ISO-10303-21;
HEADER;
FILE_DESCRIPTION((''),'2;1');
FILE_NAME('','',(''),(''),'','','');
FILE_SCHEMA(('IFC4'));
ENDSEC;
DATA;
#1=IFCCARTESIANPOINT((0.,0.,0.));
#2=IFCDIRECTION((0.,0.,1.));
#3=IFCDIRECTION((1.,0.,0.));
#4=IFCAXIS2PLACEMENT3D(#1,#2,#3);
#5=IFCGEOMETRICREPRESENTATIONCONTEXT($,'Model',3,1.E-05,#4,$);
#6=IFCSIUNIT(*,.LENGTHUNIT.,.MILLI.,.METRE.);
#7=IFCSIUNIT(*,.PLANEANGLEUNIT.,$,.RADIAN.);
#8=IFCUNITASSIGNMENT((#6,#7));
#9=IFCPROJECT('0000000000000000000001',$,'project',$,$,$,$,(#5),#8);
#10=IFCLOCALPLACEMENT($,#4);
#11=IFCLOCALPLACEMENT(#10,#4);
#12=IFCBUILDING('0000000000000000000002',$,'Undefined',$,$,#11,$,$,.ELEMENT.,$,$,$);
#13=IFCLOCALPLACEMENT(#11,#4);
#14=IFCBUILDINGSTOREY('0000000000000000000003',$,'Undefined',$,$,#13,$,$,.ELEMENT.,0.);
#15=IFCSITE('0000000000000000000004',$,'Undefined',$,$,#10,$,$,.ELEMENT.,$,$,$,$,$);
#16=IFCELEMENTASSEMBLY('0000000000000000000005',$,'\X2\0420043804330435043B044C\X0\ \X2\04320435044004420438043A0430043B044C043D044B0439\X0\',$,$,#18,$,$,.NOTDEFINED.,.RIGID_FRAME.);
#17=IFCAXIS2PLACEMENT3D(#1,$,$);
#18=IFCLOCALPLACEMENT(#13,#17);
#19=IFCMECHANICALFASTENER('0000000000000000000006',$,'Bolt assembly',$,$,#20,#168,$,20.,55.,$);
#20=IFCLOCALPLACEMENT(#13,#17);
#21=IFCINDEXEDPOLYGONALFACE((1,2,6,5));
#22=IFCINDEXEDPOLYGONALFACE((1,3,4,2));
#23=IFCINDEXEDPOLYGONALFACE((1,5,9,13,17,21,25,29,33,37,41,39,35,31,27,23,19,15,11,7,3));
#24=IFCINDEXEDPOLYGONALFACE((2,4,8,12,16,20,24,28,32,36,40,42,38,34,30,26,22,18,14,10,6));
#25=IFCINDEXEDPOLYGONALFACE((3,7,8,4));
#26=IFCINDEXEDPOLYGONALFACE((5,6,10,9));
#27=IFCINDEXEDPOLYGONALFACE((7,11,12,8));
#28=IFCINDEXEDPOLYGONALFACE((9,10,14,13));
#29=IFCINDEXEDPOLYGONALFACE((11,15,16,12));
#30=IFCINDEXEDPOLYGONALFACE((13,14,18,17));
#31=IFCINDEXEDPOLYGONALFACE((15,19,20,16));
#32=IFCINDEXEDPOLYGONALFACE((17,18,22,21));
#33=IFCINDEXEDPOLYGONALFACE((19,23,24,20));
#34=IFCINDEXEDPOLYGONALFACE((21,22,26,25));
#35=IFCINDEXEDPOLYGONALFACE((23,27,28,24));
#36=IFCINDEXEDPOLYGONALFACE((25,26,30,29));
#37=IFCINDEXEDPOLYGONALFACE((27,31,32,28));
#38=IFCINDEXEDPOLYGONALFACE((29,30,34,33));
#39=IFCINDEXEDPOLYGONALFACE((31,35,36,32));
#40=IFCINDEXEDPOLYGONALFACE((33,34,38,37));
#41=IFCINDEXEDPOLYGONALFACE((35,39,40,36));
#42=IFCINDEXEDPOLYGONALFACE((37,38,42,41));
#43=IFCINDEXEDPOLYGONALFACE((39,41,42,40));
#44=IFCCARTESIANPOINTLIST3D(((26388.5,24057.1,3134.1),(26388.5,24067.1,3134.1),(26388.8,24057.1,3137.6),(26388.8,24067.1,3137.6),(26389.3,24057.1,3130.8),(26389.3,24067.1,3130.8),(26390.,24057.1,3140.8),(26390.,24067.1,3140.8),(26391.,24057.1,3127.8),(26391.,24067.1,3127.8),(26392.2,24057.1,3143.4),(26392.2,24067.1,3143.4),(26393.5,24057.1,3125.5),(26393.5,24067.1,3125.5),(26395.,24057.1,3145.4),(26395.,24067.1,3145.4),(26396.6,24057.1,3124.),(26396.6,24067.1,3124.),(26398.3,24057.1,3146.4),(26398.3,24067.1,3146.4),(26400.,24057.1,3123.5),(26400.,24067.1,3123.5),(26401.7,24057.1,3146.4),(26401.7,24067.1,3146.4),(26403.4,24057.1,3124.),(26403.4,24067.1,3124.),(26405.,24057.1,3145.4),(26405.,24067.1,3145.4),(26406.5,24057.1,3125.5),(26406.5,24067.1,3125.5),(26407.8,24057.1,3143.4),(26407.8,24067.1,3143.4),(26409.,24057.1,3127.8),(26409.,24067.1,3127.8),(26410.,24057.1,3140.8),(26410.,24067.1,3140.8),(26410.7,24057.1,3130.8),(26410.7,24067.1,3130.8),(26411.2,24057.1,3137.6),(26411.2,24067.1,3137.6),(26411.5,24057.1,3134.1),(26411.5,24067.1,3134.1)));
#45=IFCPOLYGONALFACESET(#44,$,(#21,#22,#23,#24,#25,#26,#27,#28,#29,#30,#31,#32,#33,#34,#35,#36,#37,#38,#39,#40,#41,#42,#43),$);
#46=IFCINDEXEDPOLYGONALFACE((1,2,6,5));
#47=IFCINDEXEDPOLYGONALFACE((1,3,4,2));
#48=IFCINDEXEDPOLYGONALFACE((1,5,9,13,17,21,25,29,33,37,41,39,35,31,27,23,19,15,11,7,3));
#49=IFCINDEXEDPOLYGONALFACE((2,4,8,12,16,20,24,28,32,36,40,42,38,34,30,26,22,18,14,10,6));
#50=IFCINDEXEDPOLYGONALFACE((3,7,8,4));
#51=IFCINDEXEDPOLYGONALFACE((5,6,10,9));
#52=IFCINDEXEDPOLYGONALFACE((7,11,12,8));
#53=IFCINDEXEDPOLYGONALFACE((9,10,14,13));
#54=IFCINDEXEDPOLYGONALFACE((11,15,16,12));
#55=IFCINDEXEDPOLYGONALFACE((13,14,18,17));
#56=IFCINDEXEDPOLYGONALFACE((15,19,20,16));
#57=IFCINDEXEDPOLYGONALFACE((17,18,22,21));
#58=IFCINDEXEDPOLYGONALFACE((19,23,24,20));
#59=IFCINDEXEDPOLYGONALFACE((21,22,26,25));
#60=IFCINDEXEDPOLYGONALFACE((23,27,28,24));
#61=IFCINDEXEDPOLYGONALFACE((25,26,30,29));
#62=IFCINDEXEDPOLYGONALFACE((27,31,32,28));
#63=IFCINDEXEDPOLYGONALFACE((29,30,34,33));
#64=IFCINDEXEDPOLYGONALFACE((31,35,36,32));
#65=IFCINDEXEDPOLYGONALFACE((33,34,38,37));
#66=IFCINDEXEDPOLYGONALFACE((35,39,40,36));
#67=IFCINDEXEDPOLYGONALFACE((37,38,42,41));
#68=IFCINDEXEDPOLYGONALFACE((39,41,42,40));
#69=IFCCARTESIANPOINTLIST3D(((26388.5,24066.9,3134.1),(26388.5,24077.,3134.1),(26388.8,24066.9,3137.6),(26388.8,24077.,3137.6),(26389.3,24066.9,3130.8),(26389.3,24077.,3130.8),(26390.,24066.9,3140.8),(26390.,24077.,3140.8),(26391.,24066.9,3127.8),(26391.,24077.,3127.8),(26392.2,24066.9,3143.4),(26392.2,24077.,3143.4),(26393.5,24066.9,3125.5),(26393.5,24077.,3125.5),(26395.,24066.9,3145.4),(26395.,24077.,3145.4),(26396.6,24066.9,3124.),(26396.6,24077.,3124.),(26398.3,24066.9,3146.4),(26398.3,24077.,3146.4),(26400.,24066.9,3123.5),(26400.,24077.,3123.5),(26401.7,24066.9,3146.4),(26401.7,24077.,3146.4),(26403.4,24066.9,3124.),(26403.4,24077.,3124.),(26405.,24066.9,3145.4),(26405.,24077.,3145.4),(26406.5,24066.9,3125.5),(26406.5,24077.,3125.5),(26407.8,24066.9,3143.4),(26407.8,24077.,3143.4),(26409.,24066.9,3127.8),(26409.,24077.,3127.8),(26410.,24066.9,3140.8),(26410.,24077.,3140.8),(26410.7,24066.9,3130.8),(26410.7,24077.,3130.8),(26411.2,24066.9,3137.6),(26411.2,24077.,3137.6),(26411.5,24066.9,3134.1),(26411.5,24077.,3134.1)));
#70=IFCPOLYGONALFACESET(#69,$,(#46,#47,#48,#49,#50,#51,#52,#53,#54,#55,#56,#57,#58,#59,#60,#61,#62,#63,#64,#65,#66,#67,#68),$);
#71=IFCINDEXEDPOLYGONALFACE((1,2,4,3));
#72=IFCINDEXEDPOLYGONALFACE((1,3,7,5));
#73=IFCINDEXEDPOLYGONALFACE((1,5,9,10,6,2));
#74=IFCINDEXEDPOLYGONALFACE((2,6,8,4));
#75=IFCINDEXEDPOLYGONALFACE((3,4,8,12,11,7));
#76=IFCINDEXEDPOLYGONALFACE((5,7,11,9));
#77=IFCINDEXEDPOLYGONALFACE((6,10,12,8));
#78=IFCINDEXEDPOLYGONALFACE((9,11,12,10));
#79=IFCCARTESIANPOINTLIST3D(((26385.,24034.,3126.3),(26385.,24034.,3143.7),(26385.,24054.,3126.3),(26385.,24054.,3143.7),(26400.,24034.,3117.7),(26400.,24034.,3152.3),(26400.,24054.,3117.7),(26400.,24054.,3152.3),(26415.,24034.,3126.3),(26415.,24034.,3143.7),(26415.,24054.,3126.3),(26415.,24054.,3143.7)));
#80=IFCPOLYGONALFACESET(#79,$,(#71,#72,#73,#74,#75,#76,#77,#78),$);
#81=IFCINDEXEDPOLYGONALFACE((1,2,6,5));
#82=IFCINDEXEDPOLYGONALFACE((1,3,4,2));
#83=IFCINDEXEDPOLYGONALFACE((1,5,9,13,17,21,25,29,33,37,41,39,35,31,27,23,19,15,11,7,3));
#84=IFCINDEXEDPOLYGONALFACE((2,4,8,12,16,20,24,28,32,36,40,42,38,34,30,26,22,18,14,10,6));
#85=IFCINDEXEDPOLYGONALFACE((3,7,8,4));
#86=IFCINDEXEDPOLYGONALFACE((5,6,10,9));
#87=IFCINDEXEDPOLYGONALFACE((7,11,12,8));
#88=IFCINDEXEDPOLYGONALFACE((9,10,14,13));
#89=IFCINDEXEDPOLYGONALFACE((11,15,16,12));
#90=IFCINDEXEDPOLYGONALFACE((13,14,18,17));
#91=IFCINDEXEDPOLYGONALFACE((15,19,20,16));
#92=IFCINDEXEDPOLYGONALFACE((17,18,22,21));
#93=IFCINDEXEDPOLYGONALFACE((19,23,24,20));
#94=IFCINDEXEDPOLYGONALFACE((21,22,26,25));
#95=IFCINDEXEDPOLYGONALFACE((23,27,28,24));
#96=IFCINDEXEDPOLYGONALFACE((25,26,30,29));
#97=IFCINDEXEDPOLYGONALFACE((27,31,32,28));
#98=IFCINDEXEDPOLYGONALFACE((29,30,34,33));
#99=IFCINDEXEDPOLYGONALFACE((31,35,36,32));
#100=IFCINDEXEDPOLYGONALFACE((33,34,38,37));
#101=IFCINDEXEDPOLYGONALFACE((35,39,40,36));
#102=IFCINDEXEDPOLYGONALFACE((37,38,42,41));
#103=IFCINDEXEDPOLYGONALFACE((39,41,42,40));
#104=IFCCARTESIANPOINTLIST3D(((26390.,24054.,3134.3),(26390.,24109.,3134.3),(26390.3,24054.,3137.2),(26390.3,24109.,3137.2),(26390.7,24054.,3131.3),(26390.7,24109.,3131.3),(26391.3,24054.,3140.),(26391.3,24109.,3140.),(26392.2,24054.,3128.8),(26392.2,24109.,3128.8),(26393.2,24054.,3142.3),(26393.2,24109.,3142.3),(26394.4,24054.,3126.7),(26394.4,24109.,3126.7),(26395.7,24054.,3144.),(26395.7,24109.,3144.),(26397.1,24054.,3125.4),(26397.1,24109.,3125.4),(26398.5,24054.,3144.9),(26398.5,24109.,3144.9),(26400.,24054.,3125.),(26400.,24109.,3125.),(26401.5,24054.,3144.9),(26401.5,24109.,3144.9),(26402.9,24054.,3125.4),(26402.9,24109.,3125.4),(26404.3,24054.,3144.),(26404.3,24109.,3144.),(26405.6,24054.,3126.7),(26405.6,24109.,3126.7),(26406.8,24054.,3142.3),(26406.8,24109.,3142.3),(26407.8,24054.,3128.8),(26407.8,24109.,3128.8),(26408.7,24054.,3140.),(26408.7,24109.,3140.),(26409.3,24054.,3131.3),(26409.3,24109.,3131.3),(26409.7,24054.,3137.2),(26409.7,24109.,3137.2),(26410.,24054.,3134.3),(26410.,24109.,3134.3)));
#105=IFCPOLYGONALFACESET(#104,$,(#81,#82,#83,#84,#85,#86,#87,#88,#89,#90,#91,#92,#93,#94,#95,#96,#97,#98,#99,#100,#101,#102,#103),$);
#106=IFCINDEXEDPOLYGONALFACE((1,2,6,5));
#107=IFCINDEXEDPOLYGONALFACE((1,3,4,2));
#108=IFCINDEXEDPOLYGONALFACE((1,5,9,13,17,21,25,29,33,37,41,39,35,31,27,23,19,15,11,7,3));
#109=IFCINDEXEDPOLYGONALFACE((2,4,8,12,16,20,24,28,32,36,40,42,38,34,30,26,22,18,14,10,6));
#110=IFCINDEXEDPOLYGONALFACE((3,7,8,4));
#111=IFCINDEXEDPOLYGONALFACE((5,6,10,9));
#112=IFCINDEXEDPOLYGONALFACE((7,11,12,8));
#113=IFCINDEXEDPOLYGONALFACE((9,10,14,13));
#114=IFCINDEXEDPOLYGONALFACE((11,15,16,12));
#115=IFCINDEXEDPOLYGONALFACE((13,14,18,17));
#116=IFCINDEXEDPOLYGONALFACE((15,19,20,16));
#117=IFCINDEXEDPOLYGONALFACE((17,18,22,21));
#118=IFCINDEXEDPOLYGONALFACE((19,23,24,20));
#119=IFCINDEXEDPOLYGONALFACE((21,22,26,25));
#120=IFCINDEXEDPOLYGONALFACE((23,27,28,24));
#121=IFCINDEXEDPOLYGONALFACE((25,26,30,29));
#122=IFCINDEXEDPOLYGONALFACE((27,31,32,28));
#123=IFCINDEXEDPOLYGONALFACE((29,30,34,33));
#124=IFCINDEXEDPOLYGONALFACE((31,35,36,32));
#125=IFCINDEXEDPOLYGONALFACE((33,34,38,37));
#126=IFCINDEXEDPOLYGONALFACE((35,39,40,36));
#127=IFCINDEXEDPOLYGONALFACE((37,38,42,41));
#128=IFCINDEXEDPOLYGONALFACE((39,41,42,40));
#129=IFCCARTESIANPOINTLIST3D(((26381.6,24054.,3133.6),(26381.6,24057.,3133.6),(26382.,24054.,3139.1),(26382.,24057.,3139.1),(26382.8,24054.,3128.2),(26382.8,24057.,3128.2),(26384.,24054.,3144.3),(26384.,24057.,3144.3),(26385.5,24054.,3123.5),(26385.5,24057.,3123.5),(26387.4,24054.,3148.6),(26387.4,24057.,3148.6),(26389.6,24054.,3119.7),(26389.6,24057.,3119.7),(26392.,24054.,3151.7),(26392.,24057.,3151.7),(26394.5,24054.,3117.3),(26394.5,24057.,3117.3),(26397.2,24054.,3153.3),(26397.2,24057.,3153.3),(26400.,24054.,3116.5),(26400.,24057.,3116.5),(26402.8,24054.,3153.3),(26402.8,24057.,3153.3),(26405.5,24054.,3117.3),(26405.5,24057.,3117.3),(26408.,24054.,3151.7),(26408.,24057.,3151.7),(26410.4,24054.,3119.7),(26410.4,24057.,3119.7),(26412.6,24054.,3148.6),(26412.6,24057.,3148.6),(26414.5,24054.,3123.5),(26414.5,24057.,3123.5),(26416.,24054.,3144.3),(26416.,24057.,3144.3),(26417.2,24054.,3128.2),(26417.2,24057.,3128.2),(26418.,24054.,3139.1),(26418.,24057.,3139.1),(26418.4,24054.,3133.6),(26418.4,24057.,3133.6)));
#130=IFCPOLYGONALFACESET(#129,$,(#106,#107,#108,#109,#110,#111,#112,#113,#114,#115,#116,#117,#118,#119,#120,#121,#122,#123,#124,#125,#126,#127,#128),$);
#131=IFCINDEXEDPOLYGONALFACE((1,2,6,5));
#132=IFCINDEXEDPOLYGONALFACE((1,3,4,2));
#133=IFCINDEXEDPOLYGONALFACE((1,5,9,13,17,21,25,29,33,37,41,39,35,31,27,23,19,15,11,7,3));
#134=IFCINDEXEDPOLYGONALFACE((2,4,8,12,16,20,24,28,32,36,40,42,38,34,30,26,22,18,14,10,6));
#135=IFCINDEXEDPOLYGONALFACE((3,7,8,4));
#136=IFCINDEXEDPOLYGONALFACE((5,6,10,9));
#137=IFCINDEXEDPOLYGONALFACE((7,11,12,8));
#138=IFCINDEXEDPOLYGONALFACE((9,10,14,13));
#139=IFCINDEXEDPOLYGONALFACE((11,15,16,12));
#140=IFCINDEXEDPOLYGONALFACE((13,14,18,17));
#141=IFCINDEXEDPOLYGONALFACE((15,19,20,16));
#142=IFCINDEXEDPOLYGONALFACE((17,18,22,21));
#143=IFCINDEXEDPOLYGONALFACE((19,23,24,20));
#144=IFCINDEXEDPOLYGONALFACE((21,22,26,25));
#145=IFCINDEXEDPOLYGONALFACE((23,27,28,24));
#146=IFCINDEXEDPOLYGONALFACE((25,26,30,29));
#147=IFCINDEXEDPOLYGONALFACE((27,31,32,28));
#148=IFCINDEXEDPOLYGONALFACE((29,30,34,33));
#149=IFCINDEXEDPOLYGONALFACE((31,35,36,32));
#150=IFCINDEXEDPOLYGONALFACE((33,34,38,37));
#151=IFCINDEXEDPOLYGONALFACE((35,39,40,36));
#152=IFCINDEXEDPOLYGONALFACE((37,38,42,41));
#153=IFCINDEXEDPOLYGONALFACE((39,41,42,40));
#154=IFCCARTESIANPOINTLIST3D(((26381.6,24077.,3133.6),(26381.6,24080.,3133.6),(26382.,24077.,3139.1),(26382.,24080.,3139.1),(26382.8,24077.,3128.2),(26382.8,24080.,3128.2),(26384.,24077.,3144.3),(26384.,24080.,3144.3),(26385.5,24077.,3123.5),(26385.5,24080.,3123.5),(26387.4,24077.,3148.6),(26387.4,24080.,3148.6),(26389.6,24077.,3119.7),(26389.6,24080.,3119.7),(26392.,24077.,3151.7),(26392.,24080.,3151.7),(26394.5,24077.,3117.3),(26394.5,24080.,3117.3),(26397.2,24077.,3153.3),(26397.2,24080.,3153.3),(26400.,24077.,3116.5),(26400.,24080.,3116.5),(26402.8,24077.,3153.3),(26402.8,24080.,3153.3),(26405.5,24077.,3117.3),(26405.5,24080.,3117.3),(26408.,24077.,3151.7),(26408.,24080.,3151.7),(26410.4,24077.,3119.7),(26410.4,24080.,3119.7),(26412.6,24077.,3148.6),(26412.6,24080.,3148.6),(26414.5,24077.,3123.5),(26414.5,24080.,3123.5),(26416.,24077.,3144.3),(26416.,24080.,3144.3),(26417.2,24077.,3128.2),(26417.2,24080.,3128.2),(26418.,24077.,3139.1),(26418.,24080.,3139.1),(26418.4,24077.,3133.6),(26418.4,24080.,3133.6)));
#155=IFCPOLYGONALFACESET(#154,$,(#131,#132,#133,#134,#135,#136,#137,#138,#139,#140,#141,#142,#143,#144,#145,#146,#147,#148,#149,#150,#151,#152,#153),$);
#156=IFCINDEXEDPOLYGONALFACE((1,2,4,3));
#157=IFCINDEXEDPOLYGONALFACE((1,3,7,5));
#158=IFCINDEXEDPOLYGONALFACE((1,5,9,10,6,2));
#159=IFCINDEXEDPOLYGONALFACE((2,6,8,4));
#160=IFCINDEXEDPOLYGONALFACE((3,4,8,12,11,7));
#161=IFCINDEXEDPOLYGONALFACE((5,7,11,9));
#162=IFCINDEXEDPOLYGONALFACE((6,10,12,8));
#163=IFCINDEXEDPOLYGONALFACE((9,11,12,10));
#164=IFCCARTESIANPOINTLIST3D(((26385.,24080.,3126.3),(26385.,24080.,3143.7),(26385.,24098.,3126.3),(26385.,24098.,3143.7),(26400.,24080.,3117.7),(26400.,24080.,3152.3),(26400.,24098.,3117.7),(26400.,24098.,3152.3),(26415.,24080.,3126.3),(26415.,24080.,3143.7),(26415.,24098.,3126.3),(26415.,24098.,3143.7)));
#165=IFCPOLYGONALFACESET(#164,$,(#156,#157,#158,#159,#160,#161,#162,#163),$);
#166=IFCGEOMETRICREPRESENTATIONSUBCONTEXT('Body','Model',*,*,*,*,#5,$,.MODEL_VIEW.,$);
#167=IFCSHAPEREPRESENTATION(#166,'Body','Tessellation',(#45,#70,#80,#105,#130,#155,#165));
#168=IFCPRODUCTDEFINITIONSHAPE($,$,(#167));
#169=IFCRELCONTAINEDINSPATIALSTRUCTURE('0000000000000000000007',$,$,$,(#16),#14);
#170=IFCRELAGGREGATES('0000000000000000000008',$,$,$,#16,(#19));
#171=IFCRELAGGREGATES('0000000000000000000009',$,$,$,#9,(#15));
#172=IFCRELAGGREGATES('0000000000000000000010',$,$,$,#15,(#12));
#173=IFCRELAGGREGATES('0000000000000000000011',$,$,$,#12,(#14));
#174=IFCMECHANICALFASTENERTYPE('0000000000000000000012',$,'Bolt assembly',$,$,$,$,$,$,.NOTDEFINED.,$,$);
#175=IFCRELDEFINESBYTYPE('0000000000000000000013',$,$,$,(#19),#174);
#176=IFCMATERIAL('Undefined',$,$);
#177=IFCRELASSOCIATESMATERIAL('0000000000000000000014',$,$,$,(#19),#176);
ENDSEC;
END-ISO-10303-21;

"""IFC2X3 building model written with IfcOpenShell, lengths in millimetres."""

from ifc_helpers import new_model, si_unit, frame, origin_with_axes, origin_2d_with_axis, place, context, subcontext, project, spatial, polyline, circle, outline, extrude, source, transform, mapped, material, type_object, element, aggregate, save


model = new_model("IFC2X3")

# Units and contexts
model_context = context("Model", 3, precision=1e-05, world=origin_with_axes())
body_context = subcontext(model_context, "Body", "Model", "MODEL_VIEW")
ifc_project = project(units=[si_unit("LENGTHUNIT", "METRE", prefix="MILLI"), si_unit("PLANEANGLEUNIT", "RADIAN")], contexts=[model_context])

# Site, building, storey
site_placement = place(None, origin_with_axes())
site = spatial("IfcSite", under=ifc_project, at=site_placement, Name="Undefined", CompositionType="ELEMENT")
building_placement = place(site_placement, origin_with_axes())
building = spatial("IfcBuilding", under=site, at=building_placement, Name="Undefined", CompositionType="ELEMENT")
storey_placement = place(building_placement, origin_with_axes())
storey = spatial("IfcBuildingStorey", under=building, at=storey_placement, Name="Undefined", CompositionType="ELEMENT", Elevation=0.0)

# Element assembly
assembly_1_placement = place(storey_placement, origin_with_axes())
assembly_1 = element("IfcElementAssembly", 1, at=assembly_1_placement, inside=storey, Name="Ригель вертикальный", AssemblyPlace="NOTDEFINED", PredefinedType="RIGID_FRAME")

# Mechanical fastener
ifc_material_1 = material(Name="Undefined")
mechanical_fastener_type = type_object("IfcMechanicalFastenerType", Name="Bolt assembly")
shared_shape = source(origin_with_axes(), body_context, "Body", "SweptSolid", [
    extrude(circle(Radius=11.5, at=origin_2d_with_axis()), frame((0.0, 0.1, 0.0), z_axis=(0.0, 1.0, 0.0), x_axis=(1.0, 0.0, 0.0)), (0.0, 0.0, 1.0), 10.0),
    extrude(circle(Radius=11.5, at=origin_2d_with_axis()), frame((0.0, 9.9, 0.0), z_axis=(0.0, 1.0, 0.0), x_axis=(1.0, 0.0, 0.0)), (0.0, 0.0, 1.0), 10.1),
    extrude(outline(polyline([(17.3, 0.0), (8.7, 15.0), (-8.7, 15.0), (-17.3, 0.0), (-8.7, -15.0), (8.7, -15.0), (17.3, 0.0)])), frame((0.0, -23.0, 0.0), z_axis=(0.0, 1.0, 0.0), x_axis=(1.0, 0.0, 0.0)), (0.0, 0.0, 1.0), 20.0),
    extrude(circle(Radius=10.0, at=origin_2d_with_axis()), frame((0.0, -3.0, 0.0), z_axis=(0.0, 1.0, 0.0), x_axis=(1.0, 0.0, 0.0)), (0.0, 0.0, 1.0), 55.0),
    extrude(circle(Radius=18.5, at=origin_2d_with_axis()), frame((0.0, -3.0, 0.0), z_axis=(0.0, 1.0, 0.0), x_axis=(1.0, 0.0, 0.0)), (0.0, 0.0, 1.0), 3.0),
    extrude(circle(Radius=18.5, at=origin_2d_with_axis()), frame((0.0, 20.0, 0.0), z_axis=(0.0, 1.0, 0.0), x_axis=(1.0, 0.0, 0.0)), (0.0, 0.0, 1.0), 3.0),
    extrude(outline(polyline([(17.3, 0.0), (8.7, 15.0), (-8.7, 15.0), (-17.3, 0.0), (-8.7, -15.0), (8.7, -15.0), (17.3, 0.0)])), frame((0.0, 23.0, 0.0), z_axis=(0.0, 1.0, 0.0), x_axis=(1.0, 0.0, 0.0)), (0.0, 0.0, 1.0), 18.0),
])
mechanical_fastener_1_placement = place(assembly_1_placement, frame((26400.0, 24057.0, 3135.0), z_axis=(1.0, 0.0, 0.0), x_axis=(0.0, 0.0, -1.0)))
mechanical_fastener_1 = element("IfcMechanicalFastener", 2, at=mechanical_fastener_1_placement, type_object=mechanical_fastener_type, material=ifc_material_1, Name="Bolt assembly", NominalDiameter=20.0, NominalLength=55.0, context=body_context, shape_type="MappedRepresentation", body=[
    mapped(shared_shape, transform((0.0, 0.0, 0.0))),
])
aggregate(assembly_1, [mechanical_fastener_1])

save(model, "model.ifc")
